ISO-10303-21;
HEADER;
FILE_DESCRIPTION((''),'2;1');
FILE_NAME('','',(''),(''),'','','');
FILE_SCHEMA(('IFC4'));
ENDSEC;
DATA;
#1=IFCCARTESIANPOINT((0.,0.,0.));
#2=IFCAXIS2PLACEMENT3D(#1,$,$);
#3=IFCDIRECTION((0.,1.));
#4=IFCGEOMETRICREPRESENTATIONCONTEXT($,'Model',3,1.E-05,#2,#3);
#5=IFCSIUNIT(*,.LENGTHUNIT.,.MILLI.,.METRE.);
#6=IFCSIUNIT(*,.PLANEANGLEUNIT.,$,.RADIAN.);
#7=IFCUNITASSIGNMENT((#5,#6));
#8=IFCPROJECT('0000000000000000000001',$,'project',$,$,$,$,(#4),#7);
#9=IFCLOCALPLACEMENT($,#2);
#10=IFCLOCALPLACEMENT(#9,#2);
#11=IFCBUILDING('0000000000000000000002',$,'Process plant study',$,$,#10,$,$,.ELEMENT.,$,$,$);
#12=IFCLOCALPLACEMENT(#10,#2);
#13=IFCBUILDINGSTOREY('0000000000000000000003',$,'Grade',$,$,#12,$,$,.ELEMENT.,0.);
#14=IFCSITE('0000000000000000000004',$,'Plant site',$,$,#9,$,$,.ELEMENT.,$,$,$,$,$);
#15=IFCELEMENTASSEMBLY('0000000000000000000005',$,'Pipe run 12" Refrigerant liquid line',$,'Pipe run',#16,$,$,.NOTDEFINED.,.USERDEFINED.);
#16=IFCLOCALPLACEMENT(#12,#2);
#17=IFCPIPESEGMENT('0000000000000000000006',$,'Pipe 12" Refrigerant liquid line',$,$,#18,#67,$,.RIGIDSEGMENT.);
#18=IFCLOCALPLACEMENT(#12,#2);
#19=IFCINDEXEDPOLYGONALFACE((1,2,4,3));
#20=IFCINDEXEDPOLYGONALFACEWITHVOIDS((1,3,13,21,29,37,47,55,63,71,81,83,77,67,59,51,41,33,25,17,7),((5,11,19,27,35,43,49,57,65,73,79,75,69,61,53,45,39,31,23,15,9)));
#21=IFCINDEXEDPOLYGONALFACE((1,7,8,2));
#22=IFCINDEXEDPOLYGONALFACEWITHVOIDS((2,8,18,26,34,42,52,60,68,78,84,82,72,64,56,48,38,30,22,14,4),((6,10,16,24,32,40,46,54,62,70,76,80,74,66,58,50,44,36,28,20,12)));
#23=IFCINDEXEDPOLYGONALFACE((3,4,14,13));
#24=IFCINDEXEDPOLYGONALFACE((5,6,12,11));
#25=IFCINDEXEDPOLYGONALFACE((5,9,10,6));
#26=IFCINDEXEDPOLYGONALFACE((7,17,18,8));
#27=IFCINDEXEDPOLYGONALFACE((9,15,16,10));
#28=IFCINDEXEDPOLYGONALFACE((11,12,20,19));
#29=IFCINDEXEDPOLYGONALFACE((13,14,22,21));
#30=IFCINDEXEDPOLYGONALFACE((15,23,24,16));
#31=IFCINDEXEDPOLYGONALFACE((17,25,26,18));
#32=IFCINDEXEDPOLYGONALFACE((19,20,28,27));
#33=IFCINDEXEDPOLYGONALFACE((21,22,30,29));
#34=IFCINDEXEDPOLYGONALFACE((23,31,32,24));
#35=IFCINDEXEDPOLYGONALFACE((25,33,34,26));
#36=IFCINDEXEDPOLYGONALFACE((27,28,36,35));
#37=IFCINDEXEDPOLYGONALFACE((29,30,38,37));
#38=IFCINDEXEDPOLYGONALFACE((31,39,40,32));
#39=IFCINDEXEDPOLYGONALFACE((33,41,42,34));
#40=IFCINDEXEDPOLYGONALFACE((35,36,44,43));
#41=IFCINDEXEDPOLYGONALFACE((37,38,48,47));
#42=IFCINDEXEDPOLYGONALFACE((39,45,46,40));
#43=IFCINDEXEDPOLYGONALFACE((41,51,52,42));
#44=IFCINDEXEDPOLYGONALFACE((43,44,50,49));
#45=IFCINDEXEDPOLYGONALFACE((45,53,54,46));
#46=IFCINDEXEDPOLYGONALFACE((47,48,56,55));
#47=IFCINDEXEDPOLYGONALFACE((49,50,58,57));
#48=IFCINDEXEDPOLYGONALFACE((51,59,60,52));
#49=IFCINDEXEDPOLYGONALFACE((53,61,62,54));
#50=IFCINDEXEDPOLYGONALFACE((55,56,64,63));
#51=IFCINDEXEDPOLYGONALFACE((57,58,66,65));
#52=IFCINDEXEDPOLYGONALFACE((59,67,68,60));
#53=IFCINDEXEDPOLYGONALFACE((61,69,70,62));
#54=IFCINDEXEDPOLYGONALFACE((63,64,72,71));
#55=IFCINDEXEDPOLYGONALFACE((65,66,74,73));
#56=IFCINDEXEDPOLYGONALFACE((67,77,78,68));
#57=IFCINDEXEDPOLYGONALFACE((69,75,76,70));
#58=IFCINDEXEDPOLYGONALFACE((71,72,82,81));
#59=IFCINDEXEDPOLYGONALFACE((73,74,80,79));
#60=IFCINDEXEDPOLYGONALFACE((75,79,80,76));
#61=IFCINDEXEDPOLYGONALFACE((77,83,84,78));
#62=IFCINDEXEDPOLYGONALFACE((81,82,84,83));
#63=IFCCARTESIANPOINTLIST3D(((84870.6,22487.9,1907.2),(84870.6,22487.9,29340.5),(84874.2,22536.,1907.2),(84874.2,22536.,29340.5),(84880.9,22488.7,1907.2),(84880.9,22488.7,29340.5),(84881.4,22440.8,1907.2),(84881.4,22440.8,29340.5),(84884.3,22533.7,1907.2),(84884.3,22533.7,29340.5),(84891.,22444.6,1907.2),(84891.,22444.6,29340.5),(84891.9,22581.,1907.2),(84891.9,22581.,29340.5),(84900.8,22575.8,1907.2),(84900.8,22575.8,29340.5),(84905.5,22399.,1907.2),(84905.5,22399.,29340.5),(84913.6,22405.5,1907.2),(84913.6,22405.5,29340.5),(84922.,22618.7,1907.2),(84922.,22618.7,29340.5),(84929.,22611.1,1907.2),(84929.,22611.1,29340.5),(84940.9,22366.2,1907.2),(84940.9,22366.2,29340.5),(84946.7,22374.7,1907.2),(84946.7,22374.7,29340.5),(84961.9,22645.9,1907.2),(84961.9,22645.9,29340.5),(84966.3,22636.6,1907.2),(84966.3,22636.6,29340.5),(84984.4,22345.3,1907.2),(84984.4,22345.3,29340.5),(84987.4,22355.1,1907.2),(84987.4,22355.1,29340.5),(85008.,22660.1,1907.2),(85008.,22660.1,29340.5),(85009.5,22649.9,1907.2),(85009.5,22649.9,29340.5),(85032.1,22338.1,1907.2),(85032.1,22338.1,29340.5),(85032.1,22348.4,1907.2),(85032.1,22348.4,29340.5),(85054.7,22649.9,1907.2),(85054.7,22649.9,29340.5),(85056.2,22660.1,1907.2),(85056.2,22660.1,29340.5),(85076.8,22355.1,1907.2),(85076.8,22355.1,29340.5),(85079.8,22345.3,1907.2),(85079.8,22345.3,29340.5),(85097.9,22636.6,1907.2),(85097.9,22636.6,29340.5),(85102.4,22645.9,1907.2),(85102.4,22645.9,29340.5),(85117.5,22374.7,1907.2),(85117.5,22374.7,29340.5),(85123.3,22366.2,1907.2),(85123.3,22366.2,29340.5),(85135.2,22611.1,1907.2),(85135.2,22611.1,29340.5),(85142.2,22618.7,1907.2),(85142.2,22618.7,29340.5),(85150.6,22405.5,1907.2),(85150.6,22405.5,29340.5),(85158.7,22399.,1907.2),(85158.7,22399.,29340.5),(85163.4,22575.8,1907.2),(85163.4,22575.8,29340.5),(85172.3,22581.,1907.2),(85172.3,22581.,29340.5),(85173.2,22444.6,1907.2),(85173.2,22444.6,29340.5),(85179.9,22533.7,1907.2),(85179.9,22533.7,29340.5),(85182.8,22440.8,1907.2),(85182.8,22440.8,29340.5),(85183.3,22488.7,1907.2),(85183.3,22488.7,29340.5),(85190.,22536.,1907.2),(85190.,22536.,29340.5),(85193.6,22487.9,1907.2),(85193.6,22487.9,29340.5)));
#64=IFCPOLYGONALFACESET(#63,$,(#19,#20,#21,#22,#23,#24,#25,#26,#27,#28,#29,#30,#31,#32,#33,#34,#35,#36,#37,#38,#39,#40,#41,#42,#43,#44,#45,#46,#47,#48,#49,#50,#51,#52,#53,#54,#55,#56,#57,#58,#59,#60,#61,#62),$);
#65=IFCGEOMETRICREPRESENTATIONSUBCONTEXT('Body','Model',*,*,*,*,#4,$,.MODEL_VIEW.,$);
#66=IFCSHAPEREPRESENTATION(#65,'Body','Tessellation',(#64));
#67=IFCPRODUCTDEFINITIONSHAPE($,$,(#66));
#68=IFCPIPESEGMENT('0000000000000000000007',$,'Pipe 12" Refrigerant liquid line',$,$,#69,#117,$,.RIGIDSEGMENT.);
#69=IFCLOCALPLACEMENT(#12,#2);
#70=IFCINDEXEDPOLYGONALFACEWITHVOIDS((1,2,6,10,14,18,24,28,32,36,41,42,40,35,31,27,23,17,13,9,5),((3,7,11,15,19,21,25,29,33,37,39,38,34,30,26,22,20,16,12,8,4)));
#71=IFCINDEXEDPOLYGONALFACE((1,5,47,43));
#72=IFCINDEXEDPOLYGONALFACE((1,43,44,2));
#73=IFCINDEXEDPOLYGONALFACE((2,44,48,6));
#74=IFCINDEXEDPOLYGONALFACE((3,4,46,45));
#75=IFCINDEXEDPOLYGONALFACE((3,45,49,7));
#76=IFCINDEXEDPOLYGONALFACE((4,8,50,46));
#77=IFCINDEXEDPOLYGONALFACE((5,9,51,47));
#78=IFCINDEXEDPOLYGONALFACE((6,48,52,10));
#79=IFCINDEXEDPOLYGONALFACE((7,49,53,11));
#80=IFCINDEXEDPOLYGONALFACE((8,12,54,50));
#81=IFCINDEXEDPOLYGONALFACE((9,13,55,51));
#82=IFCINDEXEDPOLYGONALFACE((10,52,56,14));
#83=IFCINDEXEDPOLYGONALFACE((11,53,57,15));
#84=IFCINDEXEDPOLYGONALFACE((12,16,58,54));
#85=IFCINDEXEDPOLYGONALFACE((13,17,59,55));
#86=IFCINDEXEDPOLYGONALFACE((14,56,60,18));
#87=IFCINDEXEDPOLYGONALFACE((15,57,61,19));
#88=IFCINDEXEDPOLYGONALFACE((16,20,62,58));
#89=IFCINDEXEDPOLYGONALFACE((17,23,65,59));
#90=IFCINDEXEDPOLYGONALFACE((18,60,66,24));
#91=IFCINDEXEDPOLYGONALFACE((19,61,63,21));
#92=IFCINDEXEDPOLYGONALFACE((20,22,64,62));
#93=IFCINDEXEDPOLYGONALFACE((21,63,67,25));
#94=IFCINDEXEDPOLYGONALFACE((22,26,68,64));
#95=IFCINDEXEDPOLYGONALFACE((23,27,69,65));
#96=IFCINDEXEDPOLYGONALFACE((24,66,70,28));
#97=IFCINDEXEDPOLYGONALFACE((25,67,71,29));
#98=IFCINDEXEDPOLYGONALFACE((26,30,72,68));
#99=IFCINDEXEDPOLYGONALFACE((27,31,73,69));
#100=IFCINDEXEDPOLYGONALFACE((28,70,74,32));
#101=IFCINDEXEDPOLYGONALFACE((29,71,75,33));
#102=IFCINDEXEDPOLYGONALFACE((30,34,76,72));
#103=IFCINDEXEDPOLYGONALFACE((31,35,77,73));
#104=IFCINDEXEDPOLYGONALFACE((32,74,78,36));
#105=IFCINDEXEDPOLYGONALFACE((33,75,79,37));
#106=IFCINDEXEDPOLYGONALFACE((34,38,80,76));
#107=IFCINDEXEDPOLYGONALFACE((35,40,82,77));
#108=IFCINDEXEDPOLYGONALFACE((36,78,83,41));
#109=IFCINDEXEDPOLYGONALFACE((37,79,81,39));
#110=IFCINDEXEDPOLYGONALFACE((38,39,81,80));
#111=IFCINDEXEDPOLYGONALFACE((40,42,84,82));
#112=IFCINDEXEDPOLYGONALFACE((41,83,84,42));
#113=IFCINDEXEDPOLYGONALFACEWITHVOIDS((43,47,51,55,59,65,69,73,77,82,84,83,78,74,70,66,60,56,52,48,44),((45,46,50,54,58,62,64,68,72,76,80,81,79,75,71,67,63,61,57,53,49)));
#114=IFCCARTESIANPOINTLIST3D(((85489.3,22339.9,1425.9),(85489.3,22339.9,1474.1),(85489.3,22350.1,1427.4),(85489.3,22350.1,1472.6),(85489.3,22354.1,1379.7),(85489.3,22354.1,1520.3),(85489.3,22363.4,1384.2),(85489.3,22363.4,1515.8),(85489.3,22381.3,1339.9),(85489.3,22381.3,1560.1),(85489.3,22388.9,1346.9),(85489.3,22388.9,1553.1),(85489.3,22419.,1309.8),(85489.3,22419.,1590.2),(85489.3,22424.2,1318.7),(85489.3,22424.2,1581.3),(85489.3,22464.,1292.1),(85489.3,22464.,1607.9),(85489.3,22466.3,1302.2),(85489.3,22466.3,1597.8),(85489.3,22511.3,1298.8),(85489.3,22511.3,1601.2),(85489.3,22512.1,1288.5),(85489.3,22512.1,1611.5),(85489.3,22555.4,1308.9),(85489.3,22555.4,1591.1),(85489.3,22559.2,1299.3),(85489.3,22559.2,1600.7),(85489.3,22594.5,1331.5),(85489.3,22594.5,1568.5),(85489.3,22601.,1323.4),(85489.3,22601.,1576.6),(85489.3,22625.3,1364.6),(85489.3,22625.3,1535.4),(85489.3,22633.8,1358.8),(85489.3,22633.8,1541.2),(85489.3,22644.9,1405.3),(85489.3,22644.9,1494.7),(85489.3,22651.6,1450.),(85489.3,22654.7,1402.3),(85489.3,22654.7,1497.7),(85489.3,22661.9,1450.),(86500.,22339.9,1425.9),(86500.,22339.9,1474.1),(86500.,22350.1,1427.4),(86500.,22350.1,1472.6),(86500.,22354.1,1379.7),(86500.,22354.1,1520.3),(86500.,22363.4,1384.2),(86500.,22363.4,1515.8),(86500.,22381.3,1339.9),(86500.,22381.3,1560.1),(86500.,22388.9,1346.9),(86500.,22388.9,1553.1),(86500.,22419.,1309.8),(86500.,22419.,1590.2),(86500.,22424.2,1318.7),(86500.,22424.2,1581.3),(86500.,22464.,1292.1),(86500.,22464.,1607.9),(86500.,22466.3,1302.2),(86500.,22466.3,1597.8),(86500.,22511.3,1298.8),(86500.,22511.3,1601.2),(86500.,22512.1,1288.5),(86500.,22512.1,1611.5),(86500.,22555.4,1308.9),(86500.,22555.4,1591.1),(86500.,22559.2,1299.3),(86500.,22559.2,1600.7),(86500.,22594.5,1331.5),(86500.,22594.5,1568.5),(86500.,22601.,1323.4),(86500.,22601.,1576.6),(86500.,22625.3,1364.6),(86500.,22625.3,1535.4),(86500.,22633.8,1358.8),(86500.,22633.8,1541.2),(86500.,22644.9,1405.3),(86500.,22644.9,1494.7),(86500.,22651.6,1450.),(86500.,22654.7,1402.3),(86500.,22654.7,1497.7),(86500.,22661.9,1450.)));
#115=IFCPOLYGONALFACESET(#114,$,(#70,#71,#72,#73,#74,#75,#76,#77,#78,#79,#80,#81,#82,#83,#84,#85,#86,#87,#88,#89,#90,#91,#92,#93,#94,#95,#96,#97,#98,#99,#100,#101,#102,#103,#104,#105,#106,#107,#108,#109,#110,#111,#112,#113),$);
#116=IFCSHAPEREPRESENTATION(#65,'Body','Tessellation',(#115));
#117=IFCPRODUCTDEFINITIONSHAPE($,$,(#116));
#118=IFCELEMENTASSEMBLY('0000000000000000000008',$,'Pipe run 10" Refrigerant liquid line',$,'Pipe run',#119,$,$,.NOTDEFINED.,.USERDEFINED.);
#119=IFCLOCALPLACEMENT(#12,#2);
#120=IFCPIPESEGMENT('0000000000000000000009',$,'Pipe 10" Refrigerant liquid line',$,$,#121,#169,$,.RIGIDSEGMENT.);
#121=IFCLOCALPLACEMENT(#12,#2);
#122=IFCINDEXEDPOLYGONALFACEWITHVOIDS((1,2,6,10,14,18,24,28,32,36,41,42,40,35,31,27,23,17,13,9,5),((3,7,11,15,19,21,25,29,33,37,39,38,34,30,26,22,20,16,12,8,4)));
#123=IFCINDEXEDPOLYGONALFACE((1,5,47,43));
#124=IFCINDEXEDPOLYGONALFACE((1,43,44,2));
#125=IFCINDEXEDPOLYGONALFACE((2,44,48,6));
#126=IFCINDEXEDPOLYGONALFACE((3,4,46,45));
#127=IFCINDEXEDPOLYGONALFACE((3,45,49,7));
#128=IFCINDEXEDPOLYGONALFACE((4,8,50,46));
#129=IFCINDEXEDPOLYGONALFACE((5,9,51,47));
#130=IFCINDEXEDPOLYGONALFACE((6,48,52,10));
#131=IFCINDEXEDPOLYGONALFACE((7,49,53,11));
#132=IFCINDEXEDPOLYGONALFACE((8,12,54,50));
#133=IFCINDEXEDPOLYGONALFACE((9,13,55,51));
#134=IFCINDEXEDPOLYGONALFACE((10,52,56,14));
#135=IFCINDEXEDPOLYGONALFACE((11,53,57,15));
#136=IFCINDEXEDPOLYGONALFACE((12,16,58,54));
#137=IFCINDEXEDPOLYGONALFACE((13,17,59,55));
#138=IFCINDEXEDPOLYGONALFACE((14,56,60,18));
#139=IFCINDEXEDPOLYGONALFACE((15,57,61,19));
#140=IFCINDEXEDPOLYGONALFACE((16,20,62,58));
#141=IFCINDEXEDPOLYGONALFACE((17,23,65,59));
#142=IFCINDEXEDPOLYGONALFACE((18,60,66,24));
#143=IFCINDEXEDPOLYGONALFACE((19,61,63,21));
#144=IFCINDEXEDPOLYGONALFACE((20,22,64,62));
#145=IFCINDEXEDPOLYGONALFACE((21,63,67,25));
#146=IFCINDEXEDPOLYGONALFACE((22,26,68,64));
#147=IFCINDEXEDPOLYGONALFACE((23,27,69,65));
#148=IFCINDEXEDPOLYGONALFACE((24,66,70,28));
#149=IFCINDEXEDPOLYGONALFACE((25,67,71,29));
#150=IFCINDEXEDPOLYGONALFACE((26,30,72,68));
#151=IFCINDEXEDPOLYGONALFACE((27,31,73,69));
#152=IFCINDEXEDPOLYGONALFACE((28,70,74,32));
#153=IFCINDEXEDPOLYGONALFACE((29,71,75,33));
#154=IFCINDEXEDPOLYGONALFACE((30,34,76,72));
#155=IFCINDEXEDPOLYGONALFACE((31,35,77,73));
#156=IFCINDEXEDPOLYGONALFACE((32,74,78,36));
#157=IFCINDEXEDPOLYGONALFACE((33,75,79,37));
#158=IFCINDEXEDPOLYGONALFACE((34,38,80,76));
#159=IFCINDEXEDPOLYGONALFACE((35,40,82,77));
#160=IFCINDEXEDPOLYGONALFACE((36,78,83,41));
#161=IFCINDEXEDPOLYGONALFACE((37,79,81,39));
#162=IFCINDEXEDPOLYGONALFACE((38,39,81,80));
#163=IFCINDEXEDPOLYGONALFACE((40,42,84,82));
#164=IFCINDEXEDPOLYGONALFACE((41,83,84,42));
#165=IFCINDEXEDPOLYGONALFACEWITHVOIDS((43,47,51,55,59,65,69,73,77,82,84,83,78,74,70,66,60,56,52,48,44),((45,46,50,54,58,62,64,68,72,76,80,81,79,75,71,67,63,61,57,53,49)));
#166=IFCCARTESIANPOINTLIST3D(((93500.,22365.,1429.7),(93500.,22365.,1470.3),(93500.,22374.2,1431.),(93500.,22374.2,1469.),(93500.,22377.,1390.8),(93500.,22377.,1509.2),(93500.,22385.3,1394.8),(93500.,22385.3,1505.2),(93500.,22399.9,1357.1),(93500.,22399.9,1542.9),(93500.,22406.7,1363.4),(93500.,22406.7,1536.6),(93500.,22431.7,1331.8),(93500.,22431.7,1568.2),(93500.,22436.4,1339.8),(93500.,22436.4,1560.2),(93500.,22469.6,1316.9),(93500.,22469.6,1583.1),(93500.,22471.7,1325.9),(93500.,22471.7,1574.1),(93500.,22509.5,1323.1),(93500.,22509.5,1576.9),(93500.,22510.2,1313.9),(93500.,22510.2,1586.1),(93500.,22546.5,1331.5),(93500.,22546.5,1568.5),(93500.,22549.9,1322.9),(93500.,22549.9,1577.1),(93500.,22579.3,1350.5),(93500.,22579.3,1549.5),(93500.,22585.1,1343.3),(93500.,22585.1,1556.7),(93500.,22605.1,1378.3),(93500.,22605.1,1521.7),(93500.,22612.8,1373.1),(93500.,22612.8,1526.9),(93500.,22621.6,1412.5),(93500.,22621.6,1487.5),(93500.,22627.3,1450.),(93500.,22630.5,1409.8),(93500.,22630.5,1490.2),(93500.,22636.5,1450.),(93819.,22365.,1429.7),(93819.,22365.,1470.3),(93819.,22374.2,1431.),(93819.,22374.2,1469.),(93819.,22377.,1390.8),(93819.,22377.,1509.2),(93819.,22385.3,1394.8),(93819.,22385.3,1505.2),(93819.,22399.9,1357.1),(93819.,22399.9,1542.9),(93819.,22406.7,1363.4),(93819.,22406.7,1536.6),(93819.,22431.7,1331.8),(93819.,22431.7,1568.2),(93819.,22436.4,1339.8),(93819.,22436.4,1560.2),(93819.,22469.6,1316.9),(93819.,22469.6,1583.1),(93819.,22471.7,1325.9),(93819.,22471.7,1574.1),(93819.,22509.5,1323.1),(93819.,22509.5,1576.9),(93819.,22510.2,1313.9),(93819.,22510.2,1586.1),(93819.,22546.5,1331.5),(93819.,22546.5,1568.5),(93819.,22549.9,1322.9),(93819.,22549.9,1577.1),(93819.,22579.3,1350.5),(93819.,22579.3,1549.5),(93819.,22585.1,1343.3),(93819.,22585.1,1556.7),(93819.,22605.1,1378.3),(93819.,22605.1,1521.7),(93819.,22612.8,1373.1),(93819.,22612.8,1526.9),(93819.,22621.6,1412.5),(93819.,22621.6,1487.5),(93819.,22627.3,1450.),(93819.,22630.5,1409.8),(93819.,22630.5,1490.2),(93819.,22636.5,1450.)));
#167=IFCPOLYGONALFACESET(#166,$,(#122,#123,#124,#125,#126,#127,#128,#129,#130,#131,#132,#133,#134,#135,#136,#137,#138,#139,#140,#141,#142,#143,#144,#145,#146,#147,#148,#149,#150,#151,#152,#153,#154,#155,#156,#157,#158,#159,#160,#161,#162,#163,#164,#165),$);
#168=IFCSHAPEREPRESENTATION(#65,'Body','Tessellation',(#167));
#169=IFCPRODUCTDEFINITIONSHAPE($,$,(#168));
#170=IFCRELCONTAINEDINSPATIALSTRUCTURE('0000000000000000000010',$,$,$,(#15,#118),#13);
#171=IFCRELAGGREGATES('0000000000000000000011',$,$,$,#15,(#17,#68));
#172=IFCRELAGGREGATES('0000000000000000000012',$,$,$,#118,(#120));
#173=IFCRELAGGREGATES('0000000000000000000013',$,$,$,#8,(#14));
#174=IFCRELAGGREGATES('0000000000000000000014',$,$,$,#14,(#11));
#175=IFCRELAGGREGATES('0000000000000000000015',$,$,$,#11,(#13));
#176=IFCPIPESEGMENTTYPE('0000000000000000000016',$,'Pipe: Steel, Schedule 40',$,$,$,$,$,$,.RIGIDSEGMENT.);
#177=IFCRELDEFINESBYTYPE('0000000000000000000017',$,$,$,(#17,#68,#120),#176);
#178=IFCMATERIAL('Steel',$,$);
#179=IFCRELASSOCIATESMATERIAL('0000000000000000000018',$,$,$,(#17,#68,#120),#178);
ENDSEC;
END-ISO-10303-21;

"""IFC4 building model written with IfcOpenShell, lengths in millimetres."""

from ifc_helpers import new_model, si_unit, direction, frame, origin, origin_with_axes, origin_2d, place, context, subcontext, project, spatial, hollow_circle, extrude, material, type_object, element, aggregate, save


model = new_model("IFC4")

# Units and contexts
model_context = context("Model", 3, precision=1e-05, world=origin(), true_north=direction((0.0, 1.0)))
body_context = subcontext(model_context, "Body", "Model", "MODEL_VIEW")
ifc_project = project(units=[si_unit("LENGTHUNIT", "METRE", prefix="MILLI"), si_unit("PLANEANGLEUNIT", "RADIAN")], contexts=[model_context])

# Site, building, storey
site_placement = place(None, origin())
site = spatial("IfcSite", under=ifc_project, at=site_placement, Name="Plant site", CompositionType="ELEMENT")
building_placement = place(site_placement, origin())
building = spatial("IfcBuilding", under=site, at=building_placement, Name="Process plant study", CompositionType="ELEMENT")
storey_placement = place(building_placement, origin())
storey = spatial("IfcBuildingStorey", under=building, at=storey_placement, Name="Grade", CompositionType="ELEMENT", Elevation=0.0)

# Element assemblies, pipe segments
ifc_material = material(Name="Steel")
pipe_segment_type = type_object("IfcPipeSegmentType", Name="Pipe: Steel, Schedule 40", PredefinedType="RIGIDSEGMENT")
assembly_1_placement = place(storey_placement, origin_with_axes())
assembly_1 = element("IfcElementAssembly", 1, at=assembly_1_placement, inside=storey, Name="Pipe run 12\" Refrigerant liquid line", ObjectType="Pipe run", AssemblyPlace="NOTDEFINED", PredefinedType="USERDEFINED")
pipe_segment_1_placement = place(storey_placement, origin_with_axes())
pipe_segment_1 = element("IfcPipeSegment", 2, at=pipe_segment_1_placement, type_object=pipe_segment_type, material=ifc_material, Name="Pipe 12\" Refrigerant liquid line", PredefinedType="RIGIDSEGMENT", context=body_context, shape_type="SweptSolid", body=[
    extrude(hollow_circle(Radius=161.9, WallThickness=10.3, at=origin_2d()), frame((85032.1, 22500.0, 29340.5), z_axis=(0.0, 0.0, -1.0), x_axis=(0.0, -1.0, 0.0)), (0.0, 0.0, 1.0), 27433.3),
])
pipe_segment_2_placement = place(storey_placement, origin_with_axes())
pipe_segment_2 = element("IfcPipeSegment", 3, at=pipe_segment_2_placement, type_object=pipe_segment_type, material=ifc_material, Name="Pipe 12\" Refrigerant liquid line", PredefinedType="RIGIDSEGMENT", context=body_context, shape_type="SweptSolid", body=[
    extrude(hollow_circle(Radius=161.9, WallThickness=10.3, at=origin_2d()), frame((85489.3, 22500.0, 1450.0), z_axis=(1.0, 0.0, 0.0), x_axis=(0.0, 1.0, 0.0)), (0.0, 0.0, 1.0), 1010.7),
])
assembly_2_placement = place(storey_placement, origin_with_axes())
assembly_2 = element("IfcElementAssembly", 4, at=assembly_2_placement, inside=storey, Name="Pipe run 10\" Refrigerant liquid line", ObjectType="Pipe run", AssemblyPlace="NOTDEFINED", PredefinedType="USERDEFINED")
pipe_segment_3_placement = place(storey_placement, origin_with_axes())
pipe_segment_3 = element("IfcPipeSegment", 5, at=pipe_segment_3_placement, type_object=pipe_segment_type, material=ifc_material, Name="Pipe 10\" Refrigerant liquid line", PredefinedType="RIGIDSEGMENT", context=body_context, shape_type="SweptSolid", body=[
    extrude(hollow_circle(Radius=136.5, WallThickness=9.3, at=origin_2d()), frame((93500.0, 22500.0, 1450.0), z_axis=(1.0, 0.0, 0.0), x_axis=(0.0, 1.0, 0.0)), (0.0, 0.0, 1.0), 319.0),
])

aggregate(assembly_1, [pipe_segment_1, pipe_segment_2])
aggregate(assembly_2, [pipe_segment_3])

save(model, "model.ifc")
